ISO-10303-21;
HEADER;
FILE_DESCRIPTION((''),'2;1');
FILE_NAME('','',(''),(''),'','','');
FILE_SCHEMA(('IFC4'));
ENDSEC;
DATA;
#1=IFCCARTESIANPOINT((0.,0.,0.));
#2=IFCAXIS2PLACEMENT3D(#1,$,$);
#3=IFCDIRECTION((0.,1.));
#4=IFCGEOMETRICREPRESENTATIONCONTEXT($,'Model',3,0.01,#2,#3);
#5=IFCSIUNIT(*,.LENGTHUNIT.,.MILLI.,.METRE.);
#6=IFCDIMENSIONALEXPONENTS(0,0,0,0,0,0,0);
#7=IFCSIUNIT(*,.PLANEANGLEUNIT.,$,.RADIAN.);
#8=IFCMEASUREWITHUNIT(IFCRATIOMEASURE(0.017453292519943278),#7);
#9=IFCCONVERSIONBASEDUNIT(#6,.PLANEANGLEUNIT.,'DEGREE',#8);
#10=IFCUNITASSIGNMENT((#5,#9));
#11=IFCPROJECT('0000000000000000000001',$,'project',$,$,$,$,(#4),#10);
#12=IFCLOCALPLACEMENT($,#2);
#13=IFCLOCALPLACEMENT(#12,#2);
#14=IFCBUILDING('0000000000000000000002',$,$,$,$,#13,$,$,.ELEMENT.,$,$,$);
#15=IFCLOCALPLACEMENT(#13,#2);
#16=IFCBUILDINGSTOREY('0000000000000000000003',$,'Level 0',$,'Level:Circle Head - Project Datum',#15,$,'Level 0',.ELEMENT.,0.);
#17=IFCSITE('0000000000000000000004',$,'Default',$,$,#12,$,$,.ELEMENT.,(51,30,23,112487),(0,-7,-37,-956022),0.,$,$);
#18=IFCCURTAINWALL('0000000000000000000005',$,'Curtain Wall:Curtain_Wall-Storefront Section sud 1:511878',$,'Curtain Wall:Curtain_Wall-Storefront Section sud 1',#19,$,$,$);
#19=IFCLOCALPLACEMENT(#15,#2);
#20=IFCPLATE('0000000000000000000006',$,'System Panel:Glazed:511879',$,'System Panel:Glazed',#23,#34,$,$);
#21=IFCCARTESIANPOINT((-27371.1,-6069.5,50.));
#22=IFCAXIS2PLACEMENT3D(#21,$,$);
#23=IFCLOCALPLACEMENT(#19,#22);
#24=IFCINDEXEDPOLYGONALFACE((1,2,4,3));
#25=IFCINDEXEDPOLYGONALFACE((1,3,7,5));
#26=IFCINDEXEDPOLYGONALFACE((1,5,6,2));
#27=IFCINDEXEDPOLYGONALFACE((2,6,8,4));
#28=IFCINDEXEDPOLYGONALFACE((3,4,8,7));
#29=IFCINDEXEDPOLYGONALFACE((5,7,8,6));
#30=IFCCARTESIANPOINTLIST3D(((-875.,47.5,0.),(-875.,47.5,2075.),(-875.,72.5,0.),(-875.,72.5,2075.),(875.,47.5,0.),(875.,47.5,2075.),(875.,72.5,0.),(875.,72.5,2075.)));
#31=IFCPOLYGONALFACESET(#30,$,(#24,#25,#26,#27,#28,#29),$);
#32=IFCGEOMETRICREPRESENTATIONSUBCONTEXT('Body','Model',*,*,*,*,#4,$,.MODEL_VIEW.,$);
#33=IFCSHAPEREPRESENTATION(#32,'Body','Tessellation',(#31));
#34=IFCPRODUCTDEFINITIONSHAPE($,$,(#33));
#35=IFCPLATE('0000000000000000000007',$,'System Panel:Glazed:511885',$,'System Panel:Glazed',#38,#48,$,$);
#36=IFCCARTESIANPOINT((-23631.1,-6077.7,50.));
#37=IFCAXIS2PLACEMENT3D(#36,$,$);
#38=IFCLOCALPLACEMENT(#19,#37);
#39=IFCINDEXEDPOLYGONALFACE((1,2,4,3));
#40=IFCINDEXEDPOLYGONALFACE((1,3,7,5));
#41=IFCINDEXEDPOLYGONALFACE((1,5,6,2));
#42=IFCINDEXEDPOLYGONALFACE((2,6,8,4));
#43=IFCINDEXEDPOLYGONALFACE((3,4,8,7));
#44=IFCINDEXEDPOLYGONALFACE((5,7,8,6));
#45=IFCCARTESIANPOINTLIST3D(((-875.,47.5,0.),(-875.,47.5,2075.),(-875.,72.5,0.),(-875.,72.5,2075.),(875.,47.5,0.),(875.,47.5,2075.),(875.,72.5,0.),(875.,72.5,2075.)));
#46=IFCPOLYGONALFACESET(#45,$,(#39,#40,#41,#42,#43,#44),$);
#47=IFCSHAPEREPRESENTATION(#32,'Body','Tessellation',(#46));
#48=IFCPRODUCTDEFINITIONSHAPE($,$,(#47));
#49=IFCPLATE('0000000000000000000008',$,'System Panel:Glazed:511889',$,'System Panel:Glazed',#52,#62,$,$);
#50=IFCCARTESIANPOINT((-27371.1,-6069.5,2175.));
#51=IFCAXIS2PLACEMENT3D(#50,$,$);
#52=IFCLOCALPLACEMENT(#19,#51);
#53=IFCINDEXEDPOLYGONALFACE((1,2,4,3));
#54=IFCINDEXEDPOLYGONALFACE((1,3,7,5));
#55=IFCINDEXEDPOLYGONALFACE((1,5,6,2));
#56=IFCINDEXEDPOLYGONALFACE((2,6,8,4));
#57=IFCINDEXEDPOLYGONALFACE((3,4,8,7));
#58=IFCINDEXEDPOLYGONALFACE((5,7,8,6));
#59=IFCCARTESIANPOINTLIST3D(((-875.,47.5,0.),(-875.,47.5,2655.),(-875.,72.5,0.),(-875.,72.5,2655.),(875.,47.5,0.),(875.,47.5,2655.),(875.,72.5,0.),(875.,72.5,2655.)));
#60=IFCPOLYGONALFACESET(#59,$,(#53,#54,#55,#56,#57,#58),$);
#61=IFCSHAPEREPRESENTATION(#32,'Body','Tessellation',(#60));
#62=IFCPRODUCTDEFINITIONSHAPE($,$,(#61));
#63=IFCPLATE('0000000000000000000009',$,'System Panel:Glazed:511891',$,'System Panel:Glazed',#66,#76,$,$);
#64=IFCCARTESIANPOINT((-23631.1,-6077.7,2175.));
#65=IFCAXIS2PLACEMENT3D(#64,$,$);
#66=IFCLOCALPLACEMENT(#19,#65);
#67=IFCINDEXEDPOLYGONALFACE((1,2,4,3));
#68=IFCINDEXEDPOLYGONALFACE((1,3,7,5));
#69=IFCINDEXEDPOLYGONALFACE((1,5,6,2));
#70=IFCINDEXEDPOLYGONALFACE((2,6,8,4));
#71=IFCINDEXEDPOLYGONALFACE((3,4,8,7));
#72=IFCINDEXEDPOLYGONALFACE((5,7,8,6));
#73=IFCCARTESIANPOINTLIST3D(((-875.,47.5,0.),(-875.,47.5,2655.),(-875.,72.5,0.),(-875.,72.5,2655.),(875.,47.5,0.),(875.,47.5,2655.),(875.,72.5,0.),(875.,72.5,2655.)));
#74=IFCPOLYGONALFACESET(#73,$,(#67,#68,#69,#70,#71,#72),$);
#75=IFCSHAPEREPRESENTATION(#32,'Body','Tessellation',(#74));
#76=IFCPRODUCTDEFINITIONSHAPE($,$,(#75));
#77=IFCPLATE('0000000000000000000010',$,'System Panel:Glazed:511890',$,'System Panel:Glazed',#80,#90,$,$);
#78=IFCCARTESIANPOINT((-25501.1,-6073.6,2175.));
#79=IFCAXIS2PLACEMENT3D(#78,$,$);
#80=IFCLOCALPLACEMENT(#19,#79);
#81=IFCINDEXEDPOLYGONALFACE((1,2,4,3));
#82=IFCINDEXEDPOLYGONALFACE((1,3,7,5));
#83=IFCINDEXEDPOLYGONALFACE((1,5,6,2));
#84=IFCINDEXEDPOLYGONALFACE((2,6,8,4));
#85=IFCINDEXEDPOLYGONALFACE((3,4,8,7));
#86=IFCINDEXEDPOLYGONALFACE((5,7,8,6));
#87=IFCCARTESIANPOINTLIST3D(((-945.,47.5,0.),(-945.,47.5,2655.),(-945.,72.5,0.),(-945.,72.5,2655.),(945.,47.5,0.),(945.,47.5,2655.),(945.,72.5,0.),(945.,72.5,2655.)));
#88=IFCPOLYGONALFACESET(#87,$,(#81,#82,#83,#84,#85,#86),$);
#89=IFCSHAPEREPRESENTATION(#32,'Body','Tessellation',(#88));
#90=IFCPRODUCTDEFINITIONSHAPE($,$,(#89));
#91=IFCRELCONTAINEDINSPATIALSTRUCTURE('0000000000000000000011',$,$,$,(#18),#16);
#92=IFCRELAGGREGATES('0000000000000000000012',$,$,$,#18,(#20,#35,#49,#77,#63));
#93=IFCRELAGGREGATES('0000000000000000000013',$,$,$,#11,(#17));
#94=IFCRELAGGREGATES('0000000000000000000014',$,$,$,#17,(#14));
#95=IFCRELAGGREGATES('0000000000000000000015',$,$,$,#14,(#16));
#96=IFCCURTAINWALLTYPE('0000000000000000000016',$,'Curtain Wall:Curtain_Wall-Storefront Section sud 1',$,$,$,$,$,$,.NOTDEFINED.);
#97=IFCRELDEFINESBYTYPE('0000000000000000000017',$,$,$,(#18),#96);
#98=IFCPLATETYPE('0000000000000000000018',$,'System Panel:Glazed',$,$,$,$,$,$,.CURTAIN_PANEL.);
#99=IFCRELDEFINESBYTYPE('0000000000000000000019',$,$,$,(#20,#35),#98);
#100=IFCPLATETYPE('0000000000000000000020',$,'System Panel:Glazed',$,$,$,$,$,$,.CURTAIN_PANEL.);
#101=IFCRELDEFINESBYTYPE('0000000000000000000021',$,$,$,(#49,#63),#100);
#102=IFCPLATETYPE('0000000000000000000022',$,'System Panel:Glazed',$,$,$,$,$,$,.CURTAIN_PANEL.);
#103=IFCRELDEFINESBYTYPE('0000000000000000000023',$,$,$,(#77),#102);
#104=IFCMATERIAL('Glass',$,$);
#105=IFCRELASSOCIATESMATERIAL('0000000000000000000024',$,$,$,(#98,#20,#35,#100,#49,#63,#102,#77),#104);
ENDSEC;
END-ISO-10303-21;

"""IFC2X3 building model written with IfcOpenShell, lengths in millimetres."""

from ifc_helpers import new_model, entity, si_unit, converted_unit, direction, frame, frame_2d, origin, origin_2d_with_axis, place, context, subcontext, project, spatial, rectangle, extrude, source, transform, mapped, material, type_object, type_shapes, element, aggregate, save


model = new_model("IFC2X3")

# Units and contexts
model_context = context("Model", 3, precision=0.01, world=origin(), true_north=direction((0.0, 1.0)))
body_context = subcontext(model_context, "Body", "Model", "MODEL_VIEW")
ifc_project = project(units=[si_unit("LENGTHUNIT", "METRE", prefix="MILLI"), converted_unit("PLANEANGLEUNIT", "DEGREE", entity("IfcRatioMeasure", 0.017453292519943278), si_unit("PLANEANGLEUNIT", "RADIAN"), dimensions=[0, 0, 0, 0, 0, 0, 0])], contexts=[model_context])

# Site, building, storey
site_placement = place(None, origin())
site = spatial("IfcSite", under=ifc_project, at=site_placement, Name="Default", CompositionType="ELEMENT", RefLatitude=(51, 30, 23, 112487), RefLongitude=(0, -7, -37, -956022), RefElevation=0.0)
building_placement = place(site_placement, origin())
building = spatial("IfcBuilding", under=site, at=building_placement, CompositionType="ELEMENT")
storey_placement = place(building_placement, origin())
storey = spatial("IfcBuildingStorey", under=building, at=storey_placement, Name="Level 0", ObjectType="Level:Circle Head - Project Datum", LongName="Level 0", CompositionType="ELEMENT", Elevation=0.0)

# Shared definitions
curtain_wall_type = type_object("IfcCurtainWallType", Name="Curtain Wall:Curtain_Wall-Storefront Section sud 1", PredefinedType="NOTDEFINED")

# Curtain wall, plates
curtain_wall_1_placement = place(storey_placement, origin())
curtain_wall_1 = element("IfcCurtainWall", 1, at=curtain_wall_1_placement, inside=storey, type_object=curtain_wall_type, Name="Curtain Wall:Curtain_Wall-Storefront Section sud 1:511878", ObjectType="Curtain Wall:Curtain_Wall-Storefront Section sud 1")
ifc_material_1 = material(Name="Glass")
plate_type_1 = type_object("IfcPlateType", Name="System Panel:Glazed", PredefinedType="CURTAIN_PANEL", material=ifc_material_1)
shared_shape_1 = source(origin(), body_context, "Body", "SweptSolid", [
    extrude(rectangle(XDim=25.0, YDim=1750.0, at=origin_2d_with_axis()), frame((0.0, 60.0, 0.0), z_axis=(0.0, 0.0, 1.0), x_axis=(0.0, 1.0, 0.0)), (0.0, 0.0, 1.0), 2075.0),
])
type_shapes(plate_type_1, [shared_shape_1])
plate_1_placement = place(curtain_wall_1_placement, frame((-27371.1, -6069.5, 50.0)))
plate_1 = element("IfcPlate", 2, at=plate_1_placement, type_object=plate_type_1, material=ifc_material_1, Name="System Panel:Glazed:511879", ObjectType="System Panel:Glazed", context=body_context, shape_type="MappedRepresentation", body=[
    mapped(shared_shape_1, transform((0.0, 0.0, 0.0), scale=1.0)),
])
plate_2_placement = place(curtain_wall_1_placement, frame((-23631.1, -6077.7, 50.0)))
plate_2 = element("IfcPlate", 3, at=plate_2_placement, type_object=plate_type_1, material=ifc_material_1, Name="System Panel:Glazed:511885", ObjectType="System Panel:Glazed", context=body_context, shape_type="MappedRepresentation", body=[
    mapped(shared_shape_1, transform((0.0, 0.0, 0.0), scale=1.0)),
])
plate_type_2 = type_object("IfcPlateType", Name="System Panel:Glazed", PredefinedType="CURTAIN_PANEL", material=ifc_material_1)
shared_shape_2 = source(origin(), body_context, "Body", "SweptSolid", [
    extrude(rectangle(XDim=25.0, YDim=1750.0, at=frame_2d((0.0, 0.0), x_axis=(1.0, 0.0))), frame((0.0, 60.0, 0.0), z_axis=(0.0, 0.0, 1.0), x_axis=(0.0, 1.0, 0.0)), (0.0, 0.0, 1.0), 2655.0),
])
type_shapes(plate_type_2, [shared_shape_2])
plate_3_placement = place(curtain_wall_1_placement, frame((-27371.1, -6069.5, 2175.0)))
plate_3 = element("IfcPlate", 4, at=plate_3_placement, type_object=plate_type_2, material=ifc_material_1, Name="System Panel:Glazed:511889", ObjectType="System Panel:Glazed", context=body_context, shape_type="MappedRepresentation", body=[
    mapped(shared_shape_2, transform((0.0, 0.0, 0.0), scale=1.0)),
])
plate_4_placement = place(curtain_wall_1_placement, frame((-23631.1, -6077.7, 2175.0)))
plate_4 = element("IfcPlate", 5, at=plate_4_placement, type_object=plate_type_2, material=ifc_material_1, Name="System Panel:Glazed:511891", ObjectType="System Panel:Glazed", context=body_context, shape_type="MappedRepresentation", body=[
    mapped(shared_shape_2, transform((0.0, 0.0, 0.0), scale=1.0)),
])
plate_type_3 = type_object("IfcPlateType", Name="System Panel:Glazed", PredefinedType="CURTAIN_PANEL", material=ifc_material_1)
shared_shape_3 = source(origin(), body_context, "Body", "SweptSolid", [
    extrude(rectangle(XDim=25.0, YDim=1890.0, at=frame_2d((0.0, 0.0), x_axis=(1.0, 0.0))), frame((0.0, 60.0, 0.0), z_axis=(0.0, 0.0, 1.0), x_axis=(0.0, 1.0, 0.0)), (0.0, 0.0, 1.0), 2655.0),
])
type_shapes(plate_type_3, [shared_shape_3])
plate_5_placement = place(curtain_wall_1_placement, frame((-25501.1, -6073.6, 2175.0)))
plate_5 = element("IfcPlate", 6, at=plate_5_placement, type_object=plate_type_3, material=ifc_material_1, Name="System Panel:Glazed:511890", ObjectType="System Panel:Glazed", context=body_context, shape_type="MappedRepresentation", body=[
    mapped(shared_shape_3, transform((0.0, 0.0, 0.0), scale=1.0)),
])
aggregate(curtain_wall_1, [plate_1, plate_2, plate_3, plate_5, plate_4])

save(model, "model.ifc")
